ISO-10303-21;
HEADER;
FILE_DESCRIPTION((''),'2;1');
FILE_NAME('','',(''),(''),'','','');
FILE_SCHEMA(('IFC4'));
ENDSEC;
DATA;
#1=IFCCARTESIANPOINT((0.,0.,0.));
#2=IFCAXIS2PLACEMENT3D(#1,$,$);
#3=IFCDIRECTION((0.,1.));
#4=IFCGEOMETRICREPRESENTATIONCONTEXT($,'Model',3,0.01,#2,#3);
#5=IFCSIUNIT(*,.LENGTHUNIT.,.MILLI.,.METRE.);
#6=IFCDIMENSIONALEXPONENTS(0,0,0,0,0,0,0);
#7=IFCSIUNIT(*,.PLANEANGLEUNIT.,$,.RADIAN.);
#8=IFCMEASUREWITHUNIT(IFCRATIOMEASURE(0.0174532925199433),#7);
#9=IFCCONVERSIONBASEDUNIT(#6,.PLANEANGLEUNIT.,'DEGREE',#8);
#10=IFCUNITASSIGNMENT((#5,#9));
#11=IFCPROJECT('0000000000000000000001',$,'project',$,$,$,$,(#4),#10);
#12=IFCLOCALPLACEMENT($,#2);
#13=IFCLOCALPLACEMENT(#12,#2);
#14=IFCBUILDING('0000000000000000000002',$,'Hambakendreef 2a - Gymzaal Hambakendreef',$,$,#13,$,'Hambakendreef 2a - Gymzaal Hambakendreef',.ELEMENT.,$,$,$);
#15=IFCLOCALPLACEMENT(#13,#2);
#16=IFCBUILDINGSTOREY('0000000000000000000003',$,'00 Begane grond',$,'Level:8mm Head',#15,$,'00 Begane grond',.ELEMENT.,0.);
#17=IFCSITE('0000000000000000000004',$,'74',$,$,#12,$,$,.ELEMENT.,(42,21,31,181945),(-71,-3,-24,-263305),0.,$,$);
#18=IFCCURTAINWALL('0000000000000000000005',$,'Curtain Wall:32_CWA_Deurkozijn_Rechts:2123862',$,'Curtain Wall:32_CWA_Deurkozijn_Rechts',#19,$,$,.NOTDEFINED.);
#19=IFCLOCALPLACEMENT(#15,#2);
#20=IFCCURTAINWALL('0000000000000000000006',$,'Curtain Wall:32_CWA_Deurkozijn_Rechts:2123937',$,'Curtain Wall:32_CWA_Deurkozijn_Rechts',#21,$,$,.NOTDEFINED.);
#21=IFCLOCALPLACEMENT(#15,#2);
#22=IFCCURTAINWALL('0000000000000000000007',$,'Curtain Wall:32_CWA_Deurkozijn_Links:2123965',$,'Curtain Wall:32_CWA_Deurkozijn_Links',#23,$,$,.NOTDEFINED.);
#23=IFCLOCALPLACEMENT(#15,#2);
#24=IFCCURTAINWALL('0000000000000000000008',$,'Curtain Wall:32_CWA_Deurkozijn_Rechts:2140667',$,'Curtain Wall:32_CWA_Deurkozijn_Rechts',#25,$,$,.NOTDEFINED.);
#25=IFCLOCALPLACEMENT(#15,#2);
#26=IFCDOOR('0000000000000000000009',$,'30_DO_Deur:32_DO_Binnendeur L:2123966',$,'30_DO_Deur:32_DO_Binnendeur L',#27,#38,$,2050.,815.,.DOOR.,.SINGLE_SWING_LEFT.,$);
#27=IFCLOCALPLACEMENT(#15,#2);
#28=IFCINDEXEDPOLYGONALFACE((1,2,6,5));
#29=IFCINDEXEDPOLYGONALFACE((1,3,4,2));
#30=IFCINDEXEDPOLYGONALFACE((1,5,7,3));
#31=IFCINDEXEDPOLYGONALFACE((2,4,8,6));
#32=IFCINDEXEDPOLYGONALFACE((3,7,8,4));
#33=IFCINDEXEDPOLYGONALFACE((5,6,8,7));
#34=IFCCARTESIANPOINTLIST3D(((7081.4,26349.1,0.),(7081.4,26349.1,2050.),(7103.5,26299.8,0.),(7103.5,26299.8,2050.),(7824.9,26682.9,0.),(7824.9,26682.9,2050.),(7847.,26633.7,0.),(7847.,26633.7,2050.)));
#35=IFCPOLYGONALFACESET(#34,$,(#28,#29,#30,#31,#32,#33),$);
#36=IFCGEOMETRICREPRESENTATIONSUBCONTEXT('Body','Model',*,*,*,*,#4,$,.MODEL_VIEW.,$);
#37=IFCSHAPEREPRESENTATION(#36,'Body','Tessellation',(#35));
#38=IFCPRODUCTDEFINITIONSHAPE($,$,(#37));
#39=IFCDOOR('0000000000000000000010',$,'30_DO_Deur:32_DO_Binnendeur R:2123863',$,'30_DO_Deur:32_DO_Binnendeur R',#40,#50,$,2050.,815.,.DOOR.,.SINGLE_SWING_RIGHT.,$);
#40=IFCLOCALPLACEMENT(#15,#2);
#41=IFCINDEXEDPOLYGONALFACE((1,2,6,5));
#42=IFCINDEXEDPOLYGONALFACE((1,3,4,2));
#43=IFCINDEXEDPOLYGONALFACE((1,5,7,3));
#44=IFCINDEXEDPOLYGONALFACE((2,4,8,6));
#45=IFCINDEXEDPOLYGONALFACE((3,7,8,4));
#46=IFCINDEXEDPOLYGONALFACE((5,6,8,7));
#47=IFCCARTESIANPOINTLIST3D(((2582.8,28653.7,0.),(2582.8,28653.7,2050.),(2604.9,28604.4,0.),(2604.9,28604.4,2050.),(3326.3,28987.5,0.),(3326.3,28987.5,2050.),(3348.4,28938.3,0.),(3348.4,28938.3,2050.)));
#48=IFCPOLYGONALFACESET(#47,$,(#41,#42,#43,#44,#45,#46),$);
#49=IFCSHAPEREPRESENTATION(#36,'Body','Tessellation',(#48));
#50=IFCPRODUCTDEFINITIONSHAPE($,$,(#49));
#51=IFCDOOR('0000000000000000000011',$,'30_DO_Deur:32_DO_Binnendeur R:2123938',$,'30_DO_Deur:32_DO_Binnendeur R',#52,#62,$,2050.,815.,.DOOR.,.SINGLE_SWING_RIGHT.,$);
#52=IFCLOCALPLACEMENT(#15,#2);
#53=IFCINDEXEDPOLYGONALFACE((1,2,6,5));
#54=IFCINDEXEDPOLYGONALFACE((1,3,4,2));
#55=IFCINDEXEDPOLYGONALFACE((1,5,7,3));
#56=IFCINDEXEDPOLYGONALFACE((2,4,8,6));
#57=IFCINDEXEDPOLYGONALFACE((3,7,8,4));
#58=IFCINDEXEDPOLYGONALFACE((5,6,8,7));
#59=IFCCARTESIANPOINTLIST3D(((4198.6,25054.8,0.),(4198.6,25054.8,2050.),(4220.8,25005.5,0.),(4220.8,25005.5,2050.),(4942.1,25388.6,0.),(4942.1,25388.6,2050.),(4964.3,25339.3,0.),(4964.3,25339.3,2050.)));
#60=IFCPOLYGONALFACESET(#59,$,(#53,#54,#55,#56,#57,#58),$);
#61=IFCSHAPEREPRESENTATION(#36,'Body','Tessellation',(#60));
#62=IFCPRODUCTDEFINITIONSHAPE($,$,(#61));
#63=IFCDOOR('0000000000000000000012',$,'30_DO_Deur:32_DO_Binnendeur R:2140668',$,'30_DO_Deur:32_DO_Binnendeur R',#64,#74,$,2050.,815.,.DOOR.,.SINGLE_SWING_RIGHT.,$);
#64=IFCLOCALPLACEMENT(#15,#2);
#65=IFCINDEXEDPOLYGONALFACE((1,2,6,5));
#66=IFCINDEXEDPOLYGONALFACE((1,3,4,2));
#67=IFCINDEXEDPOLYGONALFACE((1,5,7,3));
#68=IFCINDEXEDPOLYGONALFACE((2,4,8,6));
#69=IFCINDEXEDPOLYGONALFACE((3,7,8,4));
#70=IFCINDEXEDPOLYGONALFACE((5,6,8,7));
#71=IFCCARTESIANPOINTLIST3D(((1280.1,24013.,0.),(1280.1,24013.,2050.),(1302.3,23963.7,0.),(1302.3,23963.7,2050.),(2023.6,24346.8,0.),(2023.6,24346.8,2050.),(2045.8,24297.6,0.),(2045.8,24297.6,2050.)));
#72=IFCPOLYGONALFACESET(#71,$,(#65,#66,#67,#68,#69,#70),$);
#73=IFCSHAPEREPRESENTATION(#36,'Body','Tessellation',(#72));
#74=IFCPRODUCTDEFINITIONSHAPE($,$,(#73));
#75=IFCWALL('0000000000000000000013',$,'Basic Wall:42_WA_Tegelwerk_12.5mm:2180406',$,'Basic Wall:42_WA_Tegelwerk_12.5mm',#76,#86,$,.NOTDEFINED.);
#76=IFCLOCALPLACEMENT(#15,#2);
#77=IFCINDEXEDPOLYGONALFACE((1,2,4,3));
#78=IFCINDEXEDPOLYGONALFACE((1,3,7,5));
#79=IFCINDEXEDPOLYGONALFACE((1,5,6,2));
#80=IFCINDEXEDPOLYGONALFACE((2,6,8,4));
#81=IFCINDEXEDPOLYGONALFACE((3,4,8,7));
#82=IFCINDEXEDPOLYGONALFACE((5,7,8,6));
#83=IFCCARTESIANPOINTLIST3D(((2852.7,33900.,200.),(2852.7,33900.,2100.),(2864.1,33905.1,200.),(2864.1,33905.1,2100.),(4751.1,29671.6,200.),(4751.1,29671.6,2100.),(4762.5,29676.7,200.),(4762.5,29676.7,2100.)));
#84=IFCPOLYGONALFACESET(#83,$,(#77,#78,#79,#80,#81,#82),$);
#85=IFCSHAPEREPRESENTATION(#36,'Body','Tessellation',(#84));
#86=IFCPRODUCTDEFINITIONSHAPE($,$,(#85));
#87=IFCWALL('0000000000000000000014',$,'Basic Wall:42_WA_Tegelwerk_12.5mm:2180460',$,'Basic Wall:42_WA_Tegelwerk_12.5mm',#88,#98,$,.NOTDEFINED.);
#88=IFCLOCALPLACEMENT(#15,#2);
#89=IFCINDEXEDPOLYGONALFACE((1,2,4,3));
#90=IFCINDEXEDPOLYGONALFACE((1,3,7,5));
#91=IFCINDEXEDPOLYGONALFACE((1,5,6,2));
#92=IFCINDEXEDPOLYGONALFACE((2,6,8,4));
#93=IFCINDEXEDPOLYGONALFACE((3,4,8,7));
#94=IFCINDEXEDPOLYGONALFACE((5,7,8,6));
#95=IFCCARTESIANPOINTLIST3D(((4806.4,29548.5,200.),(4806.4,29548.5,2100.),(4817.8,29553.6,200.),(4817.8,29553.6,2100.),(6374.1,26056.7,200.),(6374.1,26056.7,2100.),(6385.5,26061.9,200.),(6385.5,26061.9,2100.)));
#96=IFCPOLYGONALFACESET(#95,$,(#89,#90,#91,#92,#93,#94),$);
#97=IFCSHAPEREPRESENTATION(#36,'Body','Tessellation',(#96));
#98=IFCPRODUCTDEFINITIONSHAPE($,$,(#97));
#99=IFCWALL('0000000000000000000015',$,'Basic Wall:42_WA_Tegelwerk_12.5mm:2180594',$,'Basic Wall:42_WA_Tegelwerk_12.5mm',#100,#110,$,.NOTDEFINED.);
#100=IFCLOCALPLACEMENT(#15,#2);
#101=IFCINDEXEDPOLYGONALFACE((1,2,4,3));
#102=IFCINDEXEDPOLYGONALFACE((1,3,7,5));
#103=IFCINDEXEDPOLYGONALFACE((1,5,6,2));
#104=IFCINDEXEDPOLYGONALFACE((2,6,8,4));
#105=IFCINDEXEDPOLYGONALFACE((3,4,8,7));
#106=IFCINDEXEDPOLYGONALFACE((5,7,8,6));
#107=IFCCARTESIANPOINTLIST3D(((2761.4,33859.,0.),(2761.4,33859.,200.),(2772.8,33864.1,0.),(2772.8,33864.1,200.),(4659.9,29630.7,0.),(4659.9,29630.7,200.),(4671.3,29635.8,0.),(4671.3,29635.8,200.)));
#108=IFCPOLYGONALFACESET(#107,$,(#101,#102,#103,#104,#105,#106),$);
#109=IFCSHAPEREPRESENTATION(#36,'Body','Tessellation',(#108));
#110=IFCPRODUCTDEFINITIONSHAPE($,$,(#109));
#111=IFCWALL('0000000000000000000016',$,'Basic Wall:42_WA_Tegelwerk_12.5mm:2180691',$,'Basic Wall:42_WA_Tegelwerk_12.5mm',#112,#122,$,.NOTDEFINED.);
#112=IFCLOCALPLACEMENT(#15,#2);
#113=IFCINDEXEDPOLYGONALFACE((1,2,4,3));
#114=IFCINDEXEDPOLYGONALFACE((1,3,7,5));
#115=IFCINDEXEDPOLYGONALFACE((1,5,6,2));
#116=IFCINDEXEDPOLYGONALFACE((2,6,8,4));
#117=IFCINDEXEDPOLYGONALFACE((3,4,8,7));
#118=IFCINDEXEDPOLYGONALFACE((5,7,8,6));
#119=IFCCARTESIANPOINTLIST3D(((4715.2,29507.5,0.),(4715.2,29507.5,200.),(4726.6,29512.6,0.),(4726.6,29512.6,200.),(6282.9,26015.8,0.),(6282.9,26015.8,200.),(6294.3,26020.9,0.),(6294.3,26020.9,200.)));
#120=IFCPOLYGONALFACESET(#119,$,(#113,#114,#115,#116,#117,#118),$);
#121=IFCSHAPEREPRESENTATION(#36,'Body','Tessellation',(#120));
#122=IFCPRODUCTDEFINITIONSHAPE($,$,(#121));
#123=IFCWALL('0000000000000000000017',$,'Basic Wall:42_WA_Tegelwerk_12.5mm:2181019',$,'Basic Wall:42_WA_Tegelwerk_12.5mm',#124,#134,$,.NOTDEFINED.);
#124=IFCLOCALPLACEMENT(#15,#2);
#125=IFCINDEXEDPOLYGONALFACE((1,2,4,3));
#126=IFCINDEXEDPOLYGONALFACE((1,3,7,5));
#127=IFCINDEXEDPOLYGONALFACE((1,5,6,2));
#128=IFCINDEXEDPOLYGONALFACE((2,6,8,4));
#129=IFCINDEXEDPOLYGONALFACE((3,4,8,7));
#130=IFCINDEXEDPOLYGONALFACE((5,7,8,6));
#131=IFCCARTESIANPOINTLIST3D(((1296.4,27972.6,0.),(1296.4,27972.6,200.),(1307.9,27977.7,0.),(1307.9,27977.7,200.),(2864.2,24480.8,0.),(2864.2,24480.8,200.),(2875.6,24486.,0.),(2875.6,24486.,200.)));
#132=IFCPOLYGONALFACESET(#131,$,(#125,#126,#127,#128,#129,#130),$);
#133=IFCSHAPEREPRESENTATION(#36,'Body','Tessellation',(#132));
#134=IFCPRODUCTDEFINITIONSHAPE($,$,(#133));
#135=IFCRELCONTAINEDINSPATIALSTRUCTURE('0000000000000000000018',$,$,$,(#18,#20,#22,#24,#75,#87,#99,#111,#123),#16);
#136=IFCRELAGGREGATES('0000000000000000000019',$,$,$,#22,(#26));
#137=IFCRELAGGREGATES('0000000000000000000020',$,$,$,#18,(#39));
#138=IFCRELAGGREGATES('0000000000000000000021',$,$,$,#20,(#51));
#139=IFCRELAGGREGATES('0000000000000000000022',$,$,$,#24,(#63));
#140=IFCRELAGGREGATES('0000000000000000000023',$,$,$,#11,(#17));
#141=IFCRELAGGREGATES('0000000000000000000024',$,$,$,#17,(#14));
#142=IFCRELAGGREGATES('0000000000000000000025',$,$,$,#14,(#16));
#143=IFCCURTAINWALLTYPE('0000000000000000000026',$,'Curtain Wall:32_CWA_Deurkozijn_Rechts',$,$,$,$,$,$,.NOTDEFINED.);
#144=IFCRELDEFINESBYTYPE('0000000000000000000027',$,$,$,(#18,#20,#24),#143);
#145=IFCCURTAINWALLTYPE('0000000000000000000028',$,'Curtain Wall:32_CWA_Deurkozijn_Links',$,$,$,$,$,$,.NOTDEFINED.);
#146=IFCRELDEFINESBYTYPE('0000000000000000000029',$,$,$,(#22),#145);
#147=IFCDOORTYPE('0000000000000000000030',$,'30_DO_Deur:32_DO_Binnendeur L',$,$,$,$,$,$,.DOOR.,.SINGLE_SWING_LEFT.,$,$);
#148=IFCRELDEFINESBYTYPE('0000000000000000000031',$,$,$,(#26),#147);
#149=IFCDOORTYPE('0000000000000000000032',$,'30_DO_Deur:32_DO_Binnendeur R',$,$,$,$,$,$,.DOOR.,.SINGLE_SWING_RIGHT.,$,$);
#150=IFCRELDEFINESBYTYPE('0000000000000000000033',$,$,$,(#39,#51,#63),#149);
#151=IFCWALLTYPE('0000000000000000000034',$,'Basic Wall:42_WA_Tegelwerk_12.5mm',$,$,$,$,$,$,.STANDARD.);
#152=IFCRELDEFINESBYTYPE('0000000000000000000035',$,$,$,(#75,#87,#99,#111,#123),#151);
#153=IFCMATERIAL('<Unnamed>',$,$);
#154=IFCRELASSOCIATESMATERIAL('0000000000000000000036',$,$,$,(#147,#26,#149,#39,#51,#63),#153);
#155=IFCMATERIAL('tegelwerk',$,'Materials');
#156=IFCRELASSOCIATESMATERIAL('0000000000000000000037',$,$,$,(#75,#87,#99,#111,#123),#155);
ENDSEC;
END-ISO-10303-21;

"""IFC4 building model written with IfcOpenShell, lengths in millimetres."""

from ifc_helpers import new_model, entity, si_unit, converted_unit, direction, frame, origin, place, context, subcontext, project, spatial, indexed_curve, outline, extrude, source, transform, mapped, material, type_object, type_shapes, element, aggregate, save


model = new_model("IFC4")

# Units and contexts
model_context = context("Model", 3, precision=0.01, world=origin(), true_north=direction((0.0, 1.0)))
body_context = subcontext(model_context, "Body", "Model", "MODEL_VIEW")
ifc_project = project(units=[si_unit("LENGTHUNIT", "METRE", prefix="MILLI"), converted_unit("PLANEANGLEUNIT", "DEGREE", entity("IfcRatioMeasure", 0.0174532925199433), si_unit("PLANEANGLEUNIT", "RADIAN"), dimensions=[0, 0, 0, 0, 0, 0, 0])], contexts=[model_context])

# Site, building, storey
site_placement = place(None, origin())
site = spatial("IfcSite", under=ifc_project, at=site_placement, Name="74", CompositionType="ELEMENT", RefLatitude=(42, 21, 31, 181945), RefLongitude=(-71, -3, -24, -263305), RefElevation=0.0)
building_placement = place(site_placement, origin())
building = spatial("IfcBuilding", under=site, at=building_placement, Name="Hambakendreef 2a - Gymzaal Hambakendreef", LongName="Hambakendreef 2a - Gymzaal Hambakendreef", CompositionType="ELEMENT")
storey_placement = place(building_placement, origin())
storey = spatial("IfcBuildingStorey", under=building, at=storey_placement, Name="00 Begane grond", ObjectType="Level:8mm Head", LongName="00 Begane grond", CompositionType="ELEMENT", Elevation=0.0)

# Shared definitions
ifc_material_1 = material(Name="<Unnamed>")

# Curtain walls
curtain_wall_type_1 = type_object("IfcCurtainWallType", Name="Curtain Wall:32_CWA_Deurkozijn_Rechts", PredefinedType="NOTDEFINED")
curtain_wall_1_placement = place(storey_placement, origin())
curtain_wall_1 = element("IfcCurtainWall", 1, at=curtain_wall_1_placement, inside=storey, type_object=curtain_wall_type_1, Name="Curtain Wall:32_CWA_Deurkozijn_Rechts:2123862", ObjectType="Curtain Wall:32_CWA_Deurkozijn_Rechts", PredefinedType="NOTDEFINED")
curtain_wall_2_placement = place(storey_placement, origin())
curtain_wall_2 = element("IfcCurtainWall", 2, at=curtain_wall_2_placement, inside=storey, type_object=curtain_wall_type_1, Name="Curtain Wall:32_CWA_Deurkozijn_Rechts:2123937", ObjectType="Curtain Wall:32_CWA_Deurkozijn_Rechts", PredefinedType="NOTDEFINED")
curtain_wall_type_2 = type_object("IfcCurtainWallType", Name="Curtain Wall:32_CWA_Deurkozijn_Links", PredefinedType="NOTDEFINED")
curtain_wall_3_placement = place(storey_placement, origin())
curtain_wall_3 = element("IfcCurtainWall", 3, at=curtain_wall_3_placement, inside=storey, type_object=curtain_wall_type_2, Name="Curtain Wall:32_CWA_Deurkozijn_Links:2123965", ObjectType="Curtain Wall:32_CWA_Deurkozijn_Links", PredefinedType="NOTDEFINED")
curtain_wall_4_placement = place(storey_placement, origin())
curtain_wall_4 = element("IfcCurtainWall", 4, at=curtain_wall_4_placement, inside=storey, type_object=curtain_wall_type_1, Name="Curtain Wall:32_CWA_Deurkozijn_Rechts:2140667", ObjectType="Curtain Wall:32_CWA_Deurkozijn_Rechts", PredefinedType="NOTDEFINED")

# Doors
door_type_1 = type_object("IfcDoorType", Name="30_DO_Deur:32_DO_Binnendeur L", OperationType="SINGLE_SWING_LEFT", PredefinedType="DOOR", material=ifc_material_1)
shared_shape_1 = source(origin(), body_context, "Body", "SweptSolid", [
    extrude(outline(indexed_curve([(-27.0, -407.5), (27.0, -407.5), (27.0, 407.5), (-27.0, 407.5), (-27.0, -407.5)], self_intersect=False)), frame((0.0, 0.0, 0.0), z_axis=(0.0, 0.0, 1.0), x_axis=(0.0, 1.0, 0.0)), (0.0, 0.0, 1.0), 2050.0),
])
type_shapes(door_type_1, [shared_shape_1])
door_1_placement = place(curtain_wall_3_placement, frame((7464.2, 26491.4, 0.0), z_axis=(0.0, 0.0, 1.0), x_axis=(-0.91227, -0.40959, 0.0)))
door_1 = element("IfcDoor", 5, at=door_1_placement, type_object=door_type_1, material=ifc_material_1, Name="30_DO_Deur:32_DO_Binnendeur L:2123966", ObjectType="30_DO_Deur:32_DO_Binnendeur L", OperationType="SINGLE_SWING_LEFT", OverallHeight=2050.0, OverallWidth=815.0, PredefinedType="DOOR", context=body_context, shape_type="MappedRepresentation", body=[
    mapped(shared_shape_1, transform((0.0, 0.0, 0.0), scale=1.0)),
])
aggregate(curtain_wall_3, [door_1])
door_type_2 = type_object("IfcDoorType", Name="30_DO_Deur:32_DO_Binnendeur R", OperationType="SINGLE_SWING_RIGHT", PredefinedType="DOOR", material=ifc_material_1)
shared_shape_2 = source(origin(), body_context, "Body", "SweptSolid", [
    extrude(outline(indexed_curve([(-27.0, -407.5), (27.0, -407.5), (27.0, 407.5), (-27.0, 407.5), (-27.0, -407.5)], self_intersect=False)), frame((0.0, 0.0, 0.0), z_axis=(0.0, 0.0, 1.0), x_axis=(0.0, 1.0, 0.0)), (0.0, 0.0, 1.0), 2050.0),
])
type_shapes(door_type_2, [shared_shape_2])
door_2_placement = place(curtain_wall_1_placement, frame((2965.6, 28796.0, 0.0), z_axis=(0.0, 0.0, 1.0), x_axis=(0.91227, 0.40959, 0.0)))
door_2 = element("IfcDoor", 6, at=door_2_placement, type_object=door_type_2, material=ifc_material_1, Name="30_DO_Deur:32_DO_Binnendeur R:2123863", ObjectType="30_DO_Deur:32_DO_Binnendeur R", OperationType="SINGLE_SWING_RIGHT", OverallHeight=2050.0, OverallWidth=815.0, PredefinedType="DOOR", context=body_context, shape_type="MappedRepresentation", body=[
    mapped(shared_shape_2, transform((0.0, 0.0, 0.0), scale=1.0)),
])
aggregate(curtain_wall_1, [door_2])
door_3_placement = place(curtain_wall_2_placement, frame((4581.5, 25197.1, 0.0), z_axis=(0.0, 0.0, 1.0), x_axis=(0.91227, 0.40959, 0.0)))
door_3 = element("IfcDoor", 7, at=door_3_placement, type_object=door_type_2, material=ifc_material_1, Name="30_DO_Deur:32_DO_Binnendeur R:2123938", ObjectType="30_DO_Deur:32_DO_Binnendeur R", OperationType="SINGLE_SWING_RIGHT", OverallHeight=2050.0, OverallWidth=815.0, PredefinedType="DOOR", context=body_context, shape_type="MappedRepresentation", body=[
    mapped(shared_shape_2, transform((0.0, 0.0, 0.0), scale=1.0)),
])
aggregate(curtain_wall_2, [door_3])
door_4_placement = place(curtain_wall_4_placement, frame((1662.9, 24155.3, 0.0), z_axis=(0.0, 0.0, 1.0), x_axis=(0.91227, 0.40959, 0.0)))
door_4 = element("IfcDoor", 8, at=door_4_placement, type_object=door_type_2, material=ifc_material_1, Name="30_DO_Deur:32_DO_Binnendeur R:2140668", ObjectType="30_DO_Deur:32_DO_Binnendeur R", OperationType="SINGLE_SWING_RIGHT", OverallHeight=2050.0, OverallWidth=815.0, PredefinedType="DOOR", context=body_context, shape_type="MappedRepresentation", body=[
    mapped(shared_shape_2, transform((0.0, 0.0, 0.0), scale=1.0)),
])
aggregate(curtain_wall_4, [door_4])

# Walls
ifc_material_2 = material(Name="tegelwerk", Category="Materials")
wall_type_1 = type_object("IfcWallType", Name="Basic Wall:42_WA_Tegelwerk_12.5mm", PredefinedType="STANDARD")
wall_1_placement = place(storey_placement, frame((2858.4, 33902.5, 200.0), z_axis=(0.0, 0.0, 1.0), x_axis=(0.40959, -0.91227, 0.0)))
element("IfcWall", 9, at=wall_1_placement, inside=storey, type_object=wall_type_1, material=ifc_material_2, Name="Basic Wall:42_WA_Tegelwerk_12.5mm:2180406", ObjectType="Basic Wall:42_WA_Tegelwerk_12.5mm", PredefinedType="NOTDEFINED", context=body_context, shape_type="SweptSolid", body=[
    extrude(outline(indexed_curve([(4635.0, 6.2), (0.0, 6.2), (0.0, -6.2), (4635.0, -6.2), (4635.0, 6.2)], self_intersect=False)), origin(), (0.0, 0.0, 1.0), 1900.0),
])
wall_2_placement = place(storey_placement, frame((4812.1, 29551.0, 200.0), z_axis=(0.0, 0.0, 1.0), x_axis=(0.40959, -0.91227, 0.0)))
element("IfcWall", 10, at=wall_2_placement, inside=storey, type_object=wall_type_1, material=ifc_material_2, Name="Basic Wall:42_WA_Tegelwerk_12.5mm:2180460", ObjectType="Basic Wall:42_WA_Tegelwerk_12.5mm", PredefinedType="NOTDEFINED", context=body_context, shape_type="SweptSolid", body=[
    extrude(outline(indexed_curve([(3827.5, 6.2), (0.0, 6.2), (0.0, -6.2), (3827.5, -6.2), (3827.5, 6.2)], self_intersect=False)), origin(), (0.0, 0.0, 1.0), 1900.0),
])
wall_3_placement = place(storey_placement, frame((2767.1, 33861.6, 0.0), z_axis=(0.0, 0.0, 1.0), x_axis=(0.40959, -0.91227, 0.0)))
element("IfcWall", 11, at=wall_3_placement, inside=storey, type_object=wall_type_1, material=ifc_material_2, Name="Basic Wall:42_WA_Tegelwerk_12.5mm:2180594", ObjectType="Basic Wall:42_WA_Tegelwerk_12.5mm", PredefinedType="NOTDEFINED", context=body_context, shape_type="SweptSolid", body=[
    extrude(outline(indexed_curve([(4635.0, 6.2), (0.0, 6.2), (0.0, -6.2), (4635.0, -6.3), (4635.0, 6.2)], self_intersect=False)), origin(), (0.0, 0.0, 1.0), 200.0),
])
wall_4_placement = place(storey_placement, frame((4720.9, 29510.1, 0.0), z_axis=(0.0, 0.0, 1.0), x_axis=(0.40959, -0.91227, 0.0)))
element("IfcWall", 12, at=wall_4_placement, inside=storey, type_object=wall_type_1, material=ifc_material_2, Name="Basic Wall:42_WA_Tegelwerk_12.5mm:2180691", ObjectType="Basic Wall:42_WA_Tegelwerk_12.5mm", PredefinedType="NOTDEFINED", context=body_context, shape_type="SweptSolid", body=[
    extrude(outline(indexed_curve([(3827.5, 6.2), (0.0, 6.2), (0.0, -6.2), (3827.5, -6.2), (3827.5, 6.2)], self_intersect=False)), origin(), (0.0, 0.0, 1.0), 200.0),
])
wall_5_placement = place(storey_placement, frame((1302.1, 27975.1, 0.0), z_axis=(0.0, 0.0, 1.0), x_axis=(0.40959, -0.91227, 0.0)))
element("IfcWall", 13, at=wall_5_placement, inside=storey, type_object=wall_type_1, material=ifc_material_2, Name="Basic Wall:42_WA_Tegelwerk_12.5mm:2181019", ObjectType="Basic Wall:42_WA_Tegelwerk_12.5mm", PredefinedType="NOTDEFINED", context=body_context, shape_type="SweptSolid", body=[
    extrude(outline(indexed_curve([(3827.5, 6.2), (0.0, 6.2), (0.0, -6.2), (3827.5, -6.2), (3827.5, 6.2)], self_intersect=False)), origin(), (0.0, 0.0, 1.0), 200.0),
])

save(model, "model.ifc")
